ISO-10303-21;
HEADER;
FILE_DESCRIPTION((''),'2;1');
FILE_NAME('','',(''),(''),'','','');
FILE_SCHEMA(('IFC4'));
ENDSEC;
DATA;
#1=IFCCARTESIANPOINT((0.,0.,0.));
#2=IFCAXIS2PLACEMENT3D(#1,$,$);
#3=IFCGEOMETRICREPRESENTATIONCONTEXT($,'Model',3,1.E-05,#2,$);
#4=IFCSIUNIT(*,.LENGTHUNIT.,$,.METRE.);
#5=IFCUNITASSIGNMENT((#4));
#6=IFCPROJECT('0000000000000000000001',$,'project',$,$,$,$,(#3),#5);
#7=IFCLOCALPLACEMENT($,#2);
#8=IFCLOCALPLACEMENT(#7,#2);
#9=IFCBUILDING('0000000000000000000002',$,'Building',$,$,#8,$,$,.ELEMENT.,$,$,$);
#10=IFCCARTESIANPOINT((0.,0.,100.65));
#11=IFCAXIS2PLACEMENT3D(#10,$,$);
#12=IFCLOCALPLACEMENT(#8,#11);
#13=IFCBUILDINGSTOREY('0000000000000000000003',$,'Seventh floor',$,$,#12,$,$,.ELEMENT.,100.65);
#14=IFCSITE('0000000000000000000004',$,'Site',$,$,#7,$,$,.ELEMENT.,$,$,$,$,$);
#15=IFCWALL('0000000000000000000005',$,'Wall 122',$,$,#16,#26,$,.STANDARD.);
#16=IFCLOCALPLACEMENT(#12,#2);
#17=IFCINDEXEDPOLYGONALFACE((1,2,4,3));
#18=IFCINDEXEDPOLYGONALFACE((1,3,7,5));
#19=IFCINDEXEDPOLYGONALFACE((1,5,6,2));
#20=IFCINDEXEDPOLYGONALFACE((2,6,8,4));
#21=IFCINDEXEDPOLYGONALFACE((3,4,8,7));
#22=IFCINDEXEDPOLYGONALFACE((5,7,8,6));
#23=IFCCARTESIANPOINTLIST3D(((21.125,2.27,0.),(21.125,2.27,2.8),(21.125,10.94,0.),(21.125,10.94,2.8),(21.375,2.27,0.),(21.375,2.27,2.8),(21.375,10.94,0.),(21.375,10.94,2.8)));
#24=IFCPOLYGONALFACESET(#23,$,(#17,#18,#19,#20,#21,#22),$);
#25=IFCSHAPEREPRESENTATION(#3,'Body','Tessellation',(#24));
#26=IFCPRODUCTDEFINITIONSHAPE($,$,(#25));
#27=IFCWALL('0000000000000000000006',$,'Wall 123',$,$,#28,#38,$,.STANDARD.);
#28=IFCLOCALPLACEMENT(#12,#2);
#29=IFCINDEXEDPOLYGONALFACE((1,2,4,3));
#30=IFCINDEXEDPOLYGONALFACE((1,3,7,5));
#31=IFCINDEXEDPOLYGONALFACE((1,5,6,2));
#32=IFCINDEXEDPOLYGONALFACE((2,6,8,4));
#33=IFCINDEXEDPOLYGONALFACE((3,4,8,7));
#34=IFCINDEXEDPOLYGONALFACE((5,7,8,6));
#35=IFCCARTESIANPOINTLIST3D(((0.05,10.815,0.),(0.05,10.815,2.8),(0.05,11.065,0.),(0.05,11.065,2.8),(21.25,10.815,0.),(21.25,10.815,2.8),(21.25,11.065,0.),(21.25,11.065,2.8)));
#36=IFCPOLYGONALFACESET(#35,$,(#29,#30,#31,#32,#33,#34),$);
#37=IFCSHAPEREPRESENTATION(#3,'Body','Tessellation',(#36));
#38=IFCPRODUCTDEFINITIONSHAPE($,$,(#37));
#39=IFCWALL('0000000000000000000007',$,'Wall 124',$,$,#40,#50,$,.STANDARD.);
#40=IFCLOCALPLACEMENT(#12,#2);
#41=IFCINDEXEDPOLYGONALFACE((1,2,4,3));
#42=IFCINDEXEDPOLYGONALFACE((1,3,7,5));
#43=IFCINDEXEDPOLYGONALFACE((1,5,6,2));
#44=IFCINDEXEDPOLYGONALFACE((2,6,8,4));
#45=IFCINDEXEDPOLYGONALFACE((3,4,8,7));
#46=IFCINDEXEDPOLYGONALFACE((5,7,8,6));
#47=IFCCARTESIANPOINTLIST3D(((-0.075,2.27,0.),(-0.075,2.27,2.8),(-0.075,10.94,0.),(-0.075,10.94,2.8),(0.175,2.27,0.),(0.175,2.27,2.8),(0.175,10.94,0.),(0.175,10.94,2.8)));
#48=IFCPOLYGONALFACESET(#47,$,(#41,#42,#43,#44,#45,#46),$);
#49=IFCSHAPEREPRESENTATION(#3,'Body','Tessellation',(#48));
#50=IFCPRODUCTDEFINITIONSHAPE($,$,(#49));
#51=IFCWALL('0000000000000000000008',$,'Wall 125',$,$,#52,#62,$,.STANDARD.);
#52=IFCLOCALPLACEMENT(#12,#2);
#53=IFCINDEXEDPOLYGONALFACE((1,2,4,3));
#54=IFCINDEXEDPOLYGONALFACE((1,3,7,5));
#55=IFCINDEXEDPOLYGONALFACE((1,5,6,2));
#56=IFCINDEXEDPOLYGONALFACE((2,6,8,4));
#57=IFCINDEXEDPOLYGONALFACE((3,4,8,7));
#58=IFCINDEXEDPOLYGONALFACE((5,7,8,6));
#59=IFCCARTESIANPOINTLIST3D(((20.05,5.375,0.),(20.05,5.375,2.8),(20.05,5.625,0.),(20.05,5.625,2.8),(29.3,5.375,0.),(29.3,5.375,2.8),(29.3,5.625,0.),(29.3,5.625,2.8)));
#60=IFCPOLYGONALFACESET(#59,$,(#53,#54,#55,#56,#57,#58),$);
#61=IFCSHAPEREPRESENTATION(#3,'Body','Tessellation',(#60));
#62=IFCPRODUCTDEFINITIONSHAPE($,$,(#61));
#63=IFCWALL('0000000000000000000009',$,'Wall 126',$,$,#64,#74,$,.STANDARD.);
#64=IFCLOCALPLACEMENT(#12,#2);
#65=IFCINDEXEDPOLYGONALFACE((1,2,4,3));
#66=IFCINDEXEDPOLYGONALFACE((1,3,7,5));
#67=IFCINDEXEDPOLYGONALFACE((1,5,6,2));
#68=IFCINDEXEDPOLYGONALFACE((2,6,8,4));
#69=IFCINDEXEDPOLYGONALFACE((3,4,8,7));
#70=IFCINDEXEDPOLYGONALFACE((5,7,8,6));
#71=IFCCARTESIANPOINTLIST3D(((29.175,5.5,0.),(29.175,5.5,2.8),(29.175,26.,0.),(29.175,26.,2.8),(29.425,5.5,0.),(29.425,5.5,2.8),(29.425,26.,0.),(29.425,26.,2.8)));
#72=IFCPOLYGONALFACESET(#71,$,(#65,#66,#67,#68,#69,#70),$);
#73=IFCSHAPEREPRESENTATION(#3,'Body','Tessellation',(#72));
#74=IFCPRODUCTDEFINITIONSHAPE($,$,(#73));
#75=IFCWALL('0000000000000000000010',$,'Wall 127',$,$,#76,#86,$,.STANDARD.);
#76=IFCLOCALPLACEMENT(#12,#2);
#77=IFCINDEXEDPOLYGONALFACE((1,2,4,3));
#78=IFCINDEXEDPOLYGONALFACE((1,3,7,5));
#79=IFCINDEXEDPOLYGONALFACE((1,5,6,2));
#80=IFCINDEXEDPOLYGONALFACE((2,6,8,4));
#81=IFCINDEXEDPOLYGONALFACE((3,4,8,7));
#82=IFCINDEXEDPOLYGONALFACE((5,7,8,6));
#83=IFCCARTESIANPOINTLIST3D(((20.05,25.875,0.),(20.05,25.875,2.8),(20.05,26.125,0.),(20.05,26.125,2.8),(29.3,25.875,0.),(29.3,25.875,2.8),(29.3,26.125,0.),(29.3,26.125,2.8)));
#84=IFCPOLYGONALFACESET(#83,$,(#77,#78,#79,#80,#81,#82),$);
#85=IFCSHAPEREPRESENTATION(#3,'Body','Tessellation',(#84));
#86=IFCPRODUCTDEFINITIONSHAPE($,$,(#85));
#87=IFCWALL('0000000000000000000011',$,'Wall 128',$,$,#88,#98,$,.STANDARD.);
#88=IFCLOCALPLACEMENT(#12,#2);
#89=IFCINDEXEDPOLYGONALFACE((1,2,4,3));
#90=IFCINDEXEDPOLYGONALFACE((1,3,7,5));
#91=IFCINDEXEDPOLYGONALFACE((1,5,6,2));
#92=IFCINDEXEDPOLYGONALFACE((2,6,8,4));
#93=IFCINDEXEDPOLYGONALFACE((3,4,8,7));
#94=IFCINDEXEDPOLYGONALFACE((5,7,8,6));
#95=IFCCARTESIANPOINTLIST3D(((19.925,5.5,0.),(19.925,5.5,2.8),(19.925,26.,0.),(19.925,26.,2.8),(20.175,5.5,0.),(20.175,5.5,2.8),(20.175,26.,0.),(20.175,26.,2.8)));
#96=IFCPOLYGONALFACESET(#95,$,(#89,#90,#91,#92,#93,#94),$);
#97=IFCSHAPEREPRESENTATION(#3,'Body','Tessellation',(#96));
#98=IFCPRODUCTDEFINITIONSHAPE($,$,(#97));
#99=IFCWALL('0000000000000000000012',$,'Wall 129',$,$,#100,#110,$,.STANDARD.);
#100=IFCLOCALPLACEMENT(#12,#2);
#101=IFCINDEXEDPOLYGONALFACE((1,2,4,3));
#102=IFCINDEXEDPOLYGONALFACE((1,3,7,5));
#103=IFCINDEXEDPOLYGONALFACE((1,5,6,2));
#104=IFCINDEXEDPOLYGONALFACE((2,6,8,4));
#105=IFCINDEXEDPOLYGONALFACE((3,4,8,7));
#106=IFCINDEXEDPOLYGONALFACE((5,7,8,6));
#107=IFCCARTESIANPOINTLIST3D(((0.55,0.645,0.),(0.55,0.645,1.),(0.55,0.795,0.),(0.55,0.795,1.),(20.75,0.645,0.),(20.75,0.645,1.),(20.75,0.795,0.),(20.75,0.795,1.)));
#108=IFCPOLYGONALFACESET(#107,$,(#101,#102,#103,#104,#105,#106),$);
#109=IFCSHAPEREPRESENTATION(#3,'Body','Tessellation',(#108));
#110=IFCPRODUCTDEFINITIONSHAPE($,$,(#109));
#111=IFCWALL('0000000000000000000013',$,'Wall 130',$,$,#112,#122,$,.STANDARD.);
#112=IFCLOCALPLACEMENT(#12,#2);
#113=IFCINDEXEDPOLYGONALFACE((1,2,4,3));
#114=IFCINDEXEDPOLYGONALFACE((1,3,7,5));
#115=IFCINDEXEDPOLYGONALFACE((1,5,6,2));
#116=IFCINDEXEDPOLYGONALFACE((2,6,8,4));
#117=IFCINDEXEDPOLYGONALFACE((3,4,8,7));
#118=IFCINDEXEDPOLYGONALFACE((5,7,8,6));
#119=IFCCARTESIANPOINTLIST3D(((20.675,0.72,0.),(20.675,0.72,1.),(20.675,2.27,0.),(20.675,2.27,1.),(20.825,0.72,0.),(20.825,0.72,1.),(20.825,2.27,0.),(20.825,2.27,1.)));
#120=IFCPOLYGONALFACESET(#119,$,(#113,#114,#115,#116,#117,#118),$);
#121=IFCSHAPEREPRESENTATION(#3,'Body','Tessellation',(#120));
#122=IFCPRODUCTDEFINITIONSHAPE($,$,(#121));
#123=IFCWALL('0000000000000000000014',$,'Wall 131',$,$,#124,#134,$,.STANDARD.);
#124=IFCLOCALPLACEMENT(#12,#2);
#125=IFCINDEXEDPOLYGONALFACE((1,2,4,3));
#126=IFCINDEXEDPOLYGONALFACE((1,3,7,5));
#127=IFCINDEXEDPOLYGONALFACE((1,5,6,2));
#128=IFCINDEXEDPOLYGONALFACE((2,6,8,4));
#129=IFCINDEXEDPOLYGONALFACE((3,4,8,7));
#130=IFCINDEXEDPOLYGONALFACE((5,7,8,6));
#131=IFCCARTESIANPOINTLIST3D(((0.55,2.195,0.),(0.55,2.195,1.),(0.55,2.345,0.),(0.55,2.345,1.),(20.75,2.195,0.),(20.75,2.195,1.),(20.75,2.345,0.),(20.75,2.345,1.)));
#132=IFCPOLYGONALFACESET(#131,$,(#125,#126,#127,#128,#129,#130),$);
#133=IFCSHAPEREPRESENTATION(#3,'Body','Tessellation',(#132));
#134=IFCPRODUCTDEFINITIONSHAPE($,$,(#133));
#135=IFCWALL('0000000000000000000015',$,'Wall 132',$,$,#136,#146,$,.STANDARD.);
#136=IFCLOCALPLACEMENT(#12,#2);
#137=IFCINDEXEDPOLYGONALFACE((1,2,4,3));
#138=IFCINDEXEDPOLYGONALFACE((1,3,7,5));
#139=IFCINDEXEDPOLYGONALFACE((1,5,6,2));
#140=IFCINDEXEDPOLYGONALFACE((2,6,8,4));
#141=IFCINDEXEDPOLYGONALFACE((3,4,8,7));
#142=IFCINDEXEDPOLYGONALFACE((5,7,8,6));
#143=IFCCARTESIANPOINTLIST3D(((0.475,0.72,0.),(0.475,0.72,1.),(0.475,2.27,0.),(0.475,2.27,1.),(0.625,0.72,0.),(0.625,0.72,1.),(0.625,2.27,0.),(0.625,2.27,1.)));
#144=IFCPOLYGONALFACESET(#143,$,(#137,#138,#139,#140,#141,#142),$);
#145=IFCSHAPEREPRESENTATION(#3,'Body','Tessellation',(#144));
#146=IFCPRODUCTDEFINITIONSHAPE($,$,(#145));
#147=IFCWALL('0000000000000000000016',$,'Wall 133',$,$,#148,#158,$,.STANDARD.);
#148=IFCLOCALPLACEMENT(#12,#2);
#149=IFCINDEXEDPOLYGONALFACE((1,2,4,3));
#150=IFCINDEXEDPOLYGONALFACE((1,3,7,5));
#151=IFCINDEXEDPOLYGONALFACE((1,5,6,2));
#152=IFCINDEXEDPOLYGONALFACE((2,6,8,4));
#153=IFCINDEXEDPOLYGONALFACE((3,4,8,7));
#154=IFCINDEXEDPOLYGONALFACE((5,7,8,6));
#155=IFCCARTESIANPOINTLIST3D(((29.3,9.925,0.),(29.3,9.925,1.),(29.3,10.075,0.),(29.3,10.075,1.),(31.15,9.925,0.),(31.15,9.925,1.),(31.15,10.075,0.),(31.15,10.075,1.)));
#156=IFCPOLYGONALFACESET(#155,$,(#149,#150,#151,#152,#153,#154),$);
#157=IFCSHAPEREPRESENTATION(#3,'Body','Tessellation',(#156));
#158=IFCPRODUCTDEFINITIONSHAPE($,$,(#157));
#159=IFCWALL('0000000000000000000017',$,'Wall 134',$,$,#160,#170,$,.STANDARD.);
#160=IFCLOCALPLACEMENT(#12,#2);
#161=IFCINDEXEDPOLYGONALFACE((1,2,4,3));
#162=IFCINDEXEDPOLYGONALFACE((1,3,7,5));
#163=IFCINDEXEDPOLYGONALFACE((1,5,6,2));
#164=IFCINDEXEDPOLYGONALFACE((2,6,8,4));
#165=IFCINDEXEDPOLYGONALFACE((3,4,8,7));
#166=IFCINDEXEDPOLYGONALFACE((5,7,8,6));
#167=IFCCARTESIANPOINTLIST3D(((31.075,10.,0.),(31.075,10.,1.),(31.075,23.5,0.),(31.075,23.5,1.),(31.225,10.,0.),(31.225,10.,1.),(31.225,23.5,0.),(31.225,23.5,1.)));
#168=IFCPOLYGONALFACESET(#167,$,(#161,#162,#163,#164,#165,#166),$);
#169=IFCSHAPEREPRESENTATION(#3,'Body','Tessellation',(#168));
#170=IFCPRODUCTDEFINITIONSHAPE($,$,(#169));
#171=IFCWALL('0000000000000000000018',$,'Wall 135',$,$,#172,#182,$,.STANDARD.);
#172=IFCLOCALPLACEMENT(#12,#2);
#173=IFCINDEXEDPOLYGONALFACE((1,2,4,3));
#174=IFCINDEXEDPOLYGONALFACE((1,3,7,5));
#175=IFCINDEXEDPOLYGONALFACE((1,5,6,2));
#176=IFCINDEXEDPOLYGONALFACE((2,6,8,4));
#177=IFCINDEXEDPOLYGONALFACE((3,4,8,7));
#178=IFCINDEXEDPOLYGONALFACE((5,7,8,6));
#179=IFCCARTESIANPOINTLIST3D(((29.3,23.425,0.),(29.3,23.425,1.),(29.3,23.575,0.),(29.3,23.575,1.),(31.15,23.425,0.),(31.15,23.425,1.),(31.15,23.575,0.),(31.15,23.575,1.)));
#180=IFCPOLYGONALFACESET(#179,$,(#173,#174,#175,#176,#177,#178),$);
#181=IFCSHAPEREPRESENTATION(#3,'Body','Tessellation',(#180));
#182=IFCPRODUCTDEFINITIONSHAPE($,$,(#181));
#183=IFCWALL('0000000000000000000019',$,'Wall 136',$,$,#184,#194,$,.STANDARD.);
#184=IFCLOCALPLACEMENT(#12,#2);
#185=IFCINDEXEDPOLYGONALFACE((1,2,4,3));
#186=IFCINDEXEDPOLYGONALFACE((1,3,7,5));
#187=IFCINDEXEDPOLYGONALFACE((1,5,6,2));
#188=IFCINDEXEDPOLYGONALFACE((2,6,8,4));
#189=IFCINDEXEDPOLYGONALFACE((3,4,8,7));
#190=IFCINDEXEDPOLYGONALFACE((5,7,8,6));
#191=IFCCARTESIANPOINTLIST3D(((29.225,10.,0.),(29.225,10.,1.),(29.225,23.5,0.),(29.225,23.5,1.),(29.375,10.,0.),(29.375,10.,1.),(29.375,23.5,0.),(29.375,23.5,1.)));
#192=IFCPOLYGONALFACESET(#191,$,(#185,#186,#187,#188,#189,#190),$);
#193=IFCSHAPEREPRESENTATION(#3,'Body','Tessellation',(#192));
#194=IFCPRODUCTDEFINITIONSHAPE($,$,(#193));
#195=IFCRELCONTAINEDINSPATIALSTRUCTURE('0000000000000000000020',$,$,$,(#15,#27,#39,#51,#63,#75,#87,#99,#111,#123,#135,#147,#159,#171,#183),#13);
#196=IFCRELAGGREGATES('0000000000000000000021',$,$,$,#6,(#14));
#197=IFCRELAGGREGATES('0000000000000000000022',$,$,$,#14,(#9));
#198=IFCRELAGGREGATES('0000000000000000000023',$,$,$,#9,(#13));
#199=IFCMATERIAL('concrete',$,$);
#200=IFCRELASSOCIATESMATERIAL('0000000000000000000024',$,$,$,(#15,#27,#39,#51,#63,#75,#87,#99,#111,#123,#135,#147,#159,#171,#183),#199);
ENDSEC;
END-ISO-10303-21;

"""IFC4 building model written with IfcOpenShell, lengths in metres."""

from ifc_helpers import new_model, si_unit, frame, frame_2d, origin, place, context, project, spatial, rectangle, extrude, material, element, save


model = new_model("IFC4")

# Units and contexts
model_context = context("Model", 3, precision=1e-05, world=origin())
ifc_project = project(units=[si_unit("LENGTHUNIT", "METRE")], contexts=[model_context])

# Site, building, storey
site_placement = place(None, origin())
site = spatial("IfcSite", under=ifc_project, at=site_placement, Name="Site", CompositionType="ELEMENT")
building_placement = place(site_placement, origin())
building = spatial("IfcBuilding", under=site, at=building_placement, Name="Building", CompositionType="ELEMENT")
storey_placement = place(building_placement, frame((0.0, 0.0, 100.65)))
storey = spatial("IfcBuildingStorey", under=building, at=storey_placement, Name="Seventh floor", CompositionType="ELEMENT", Elevation=100.65)

# Shared definitions
ifc_material = material(Name="concrete")

# Walls
wall_1_placement = place(storey_placement, frame((21.25, 2.27, 0.0), z_axis=(0.0, 0.0, 1.0), x_axis=(0.0, 1.0, 0.0)))
element("IfcWall", 1, at=wall_1_placement, inside=storey, material=ifc_material, Name="Wall 122", PredefinedType="STANDARD", context=model_context, shape_type="SweptSolid", body=[
    extrude(rectangle(XDim=8.67, YDim=0.25, at=frame_2d((4.335, 0.0))), origin(), (0.0, 0.0, 1.0), 2.8),
])
wall_2_placement = place(storey_placement, frame((21.25, 10.94, 0.0), z_axis=(0.0, 0.0, 1.0), x_axis=(-1.0, 0.0, 0.0)))
element("IfcWall", 2, at=wall_2_placement, inside=storey, material=ifc_material, Name="Wall 123", PredefinedType="STANDARD", context=model_context, shape_type="SweptSolid", body=[
    extrude(rectangle(XDim=21.2, YDim=0.25, at=frame_2d((10.6, 0.0))), origin(), (0.0, 0.0, 1.0), 2.8),
])
wall_3_placement = place(storey_placement, frame((0.05, 10.94, 0.0), z_axis=(0.0, 0.0, 1.0), x_axis=(0.0, -1.0, 0.0)))
element("IfcWall", 3, at=wall_3_placement, inside=storey, material=ifc_material, Name="Wall 124", PredefinedType="STANDARD", context=model_context, shape_type="SweptSolid", body=[
    extrude(rectangle(XDim=8.67, YDim=0.25, at=frame_2d((4.335, 0.0))), origin(), (0.0, 0.0, 1.0), 2.8),
])
wall_4_placement = place(storey_placement, frame((20.05, 5.5, 0.0), z_axis=(0.0, 0.0, 1.0), x_axis=(1.0, 0.0, 0.0)))
element("IfcWall", 4, at=wall_4_placement, inside=storey, material=ifc_material, Name="Wall 125", PredefinedType="STANDARD", context=model_context, shape_type="SweptSolid", body=[
    extrude(rectangle(XDim=9.25, YDim=0.25, at=frame_2d((4.625, 0.0))), origin(), (0.0, 0.0, 1.0), 2.8),
])
wall_5_placement = place(storey_placement, frame((29.3, 5.5, 0.0), z_axis=(0.0, 0.0, 1.0), x_axis=(0.0, 1.0, 0.0)))
element("IfcWall", 5, at=wall_5_placement, inside=storey, material=ifc_material, Name="Wall 126", PredefinedType="STANDARD", context=model_context, shape_type="SweptSolid", body=[
    extrude(rectangle(XDim=20.5, YDim=0.25, at=frame_2d((10.25, 0.0))), origin(), (0.0, 0.0, 1.0), 2.8),
])
wall_6_placement = place(storey_placement, frame((29.3, 26.0, 0.0), z_axis=(0.0, 0.0, 1.0), x_axis=(-1.0, 0.0, 0.0)))
element("IfcWall", 6, at=wall_6_placement, inside=storey, material=ifc_material, Name="Wall 127", PredefinedType="STANDARD", context=model_context, shape_type="SweptSolid", body=[
    extrude(rectangle(XDim=9.25, YDim=0.25, at=frame_2d((4.625, 0.0))), origin(), (0.0, 0.0, 1.0), 2.8),
])
wall_7_placement = place(storey_placement, frame((20.05, 26.0, 0.0), z_axis=(0.0, 0.0, 1.0), x_axis=(0.0, -1.0, 0.0)))
element("IfcWall", 7, at=wall_7_placement, inside=storey, material=ifc_material, Name="Wall 128", PredefinedType="STANDARD", context=model_context, shape_type="SweptSolid", body=[
    extrude(rectangle(XDim=20.5, YDim=0.25, at=frame_2d((10.25, 0.0))), origin(), (0.0, 0.0, 1.0), 2.8),
])
wall_8_placement = place(storey_placement, frame((0.55, 0.72, 0.0), z_axis=(0.0, 0.0, 1.0), x_axis=(1.0, 0.0, 0.0)))
element("IfcWall", 8, at=wall_8_placement, inside=storey, material=ifc_material, Name="Wall 129", PredefinedType="STANDARD", context=model_context, shape_type="SweptSolid", body=[
    extrude(rectangle(XDim=20.2, YDim=0.15, at=frame_2d((10.1, 0.0))), origin(), (0.0, 0.0, 1.0), 1.0),
])
wall_9_placement = place(storey_placement, frame((20.75, 0.72, 0.0), z_axis=(0.0, 0.0, 1.0), x_axis=(0.0, 1.0, 0.0)))
element("IfcWall", 9, at=wall_9_placement, inside=storey, material=ifc_material, Name="Wall 130", PredefinedType="STANDARD", context=model_context, shape_type="SweptSolid", body=[
    extrude(rectangle(XDim=1.55, YDim=0.15, at=frame_2d((0.775, 0.0))), origin(), (0.0, 0.0, 1.0), 1.0),
])
wall_10_placement = place(storey_placement, frame((20.75, 2.27, 0.0), z_axis=(0.0, 0.0, 1.0), x_axis=(-1.0, 0.0, 0.0)))
element("IfcWall", 10, at=wall_10_placement, inside=storey, material=ifc_material, Name="Wall 131", PredefinedType="STANDARD", context=model_context, shape_type="SweptSolid", body=[
    extrude(rectangle(XDim=20.2, YDim=0.15, at=frame_2d((10.1, 0.0))), origin(), (0.0, 0.0, 1.0), 1.0),
])
wall_11_placement = place(storey_placement, frame((0.55, 2.27, 0.0), z_axis=(0.0, 0.0, 1.0), x_axis=(0.0, -1.0, 0.0)))
element("IfcWall", 11, at=wall_11_placement, inside=storey, material=ifc_material, Name="Wall 132", PredefinedType="STANDARD", context=model_context, shape_type="SweptSolid", body=[
    extrude(rectangle(XDim=1.55, YDim=0.15, at=frame_2d((0.775, 0.0))), origin(), (0.0, 0.0, 1.0), 1.0),
])
wall_12_placement = place(storey_placement, frame((29.3, 10.0, 0.0), z_axis=(0.0, 0.0, 1.0), x_axis=(1.0, 0.0, 0.0)))
element("IfcWall", 12, at=wall_12_placement, inside=storey, material=ifc_material, Name="Wall 133", PredefinedType="STANDARD", context=model_context, shape_type="SweptSolid", body=[
    extrude(rectangle(XDim=1.85, YDim=0.15, at=frame_2d((0.925, 0.0))), origin(), (0.0, 0.0, 1.0), 1.0),
])
wall_13_placement = place(storey_placement, frame((31.15, 10.0, 0.0), z_axis=(0.0, 0.0, 1.0), x_axis=(0.0, 1.0, 0.0)))
element("IfcWall", 13, at=wall_13_placement, inside=storey, material=ifc_material, Name="Wall 134", PredefinedType="STANDARD", context=model_context, shape_type="SweptSolid", body=[
    extrude(rectangle(XDim=13.5, YDim=0.15, at=frame_2d((6.75, 0.0))), origin(), (0.0, 0.0, 1.0), 1.0),
])
wall_14_placement = place(storey_placement, frame((31.15, 23.5, 0.0), z_axis=(0.0, 0.0, 1.0), x_axis=(-1.0, 0.0, 0.0)))
element("IfcWall", 14, at=wall_14_placement, inside=storey, material=ifc_material, Name="Wall 135", PredefinedType="STANDARD", context=model_context, shape_type="SweptSolid", body=[
    extrude(rectangle(XDim=1.85, YDim=0.15, at=frame_2d((0.925, 0.0))), origin(), (0.0, 0.0, 1.0), 1.0),
])
wall_15_placement = place(storey_placement, frame((29.3, 23.5, 0.0), z_axis=(0.0, 0.0, 1.0), x_axis=(0.0, -1.0, 0.0)))
element("IfcWall", 15, at=wall_15_placement, inside=storey, material=ifc_material, Name="Wall 136", PredefinedType="STANDARD", context=model_context, shape_type="SweptSolid", body=[
    extrude(rectangle(XDim=13.5, YDim=0.15, at=frame_2d((6.75, 0.0))), origin(), (0.0, 0.0, 1.0), 1.0),
])

save(model, "model.ifc")
